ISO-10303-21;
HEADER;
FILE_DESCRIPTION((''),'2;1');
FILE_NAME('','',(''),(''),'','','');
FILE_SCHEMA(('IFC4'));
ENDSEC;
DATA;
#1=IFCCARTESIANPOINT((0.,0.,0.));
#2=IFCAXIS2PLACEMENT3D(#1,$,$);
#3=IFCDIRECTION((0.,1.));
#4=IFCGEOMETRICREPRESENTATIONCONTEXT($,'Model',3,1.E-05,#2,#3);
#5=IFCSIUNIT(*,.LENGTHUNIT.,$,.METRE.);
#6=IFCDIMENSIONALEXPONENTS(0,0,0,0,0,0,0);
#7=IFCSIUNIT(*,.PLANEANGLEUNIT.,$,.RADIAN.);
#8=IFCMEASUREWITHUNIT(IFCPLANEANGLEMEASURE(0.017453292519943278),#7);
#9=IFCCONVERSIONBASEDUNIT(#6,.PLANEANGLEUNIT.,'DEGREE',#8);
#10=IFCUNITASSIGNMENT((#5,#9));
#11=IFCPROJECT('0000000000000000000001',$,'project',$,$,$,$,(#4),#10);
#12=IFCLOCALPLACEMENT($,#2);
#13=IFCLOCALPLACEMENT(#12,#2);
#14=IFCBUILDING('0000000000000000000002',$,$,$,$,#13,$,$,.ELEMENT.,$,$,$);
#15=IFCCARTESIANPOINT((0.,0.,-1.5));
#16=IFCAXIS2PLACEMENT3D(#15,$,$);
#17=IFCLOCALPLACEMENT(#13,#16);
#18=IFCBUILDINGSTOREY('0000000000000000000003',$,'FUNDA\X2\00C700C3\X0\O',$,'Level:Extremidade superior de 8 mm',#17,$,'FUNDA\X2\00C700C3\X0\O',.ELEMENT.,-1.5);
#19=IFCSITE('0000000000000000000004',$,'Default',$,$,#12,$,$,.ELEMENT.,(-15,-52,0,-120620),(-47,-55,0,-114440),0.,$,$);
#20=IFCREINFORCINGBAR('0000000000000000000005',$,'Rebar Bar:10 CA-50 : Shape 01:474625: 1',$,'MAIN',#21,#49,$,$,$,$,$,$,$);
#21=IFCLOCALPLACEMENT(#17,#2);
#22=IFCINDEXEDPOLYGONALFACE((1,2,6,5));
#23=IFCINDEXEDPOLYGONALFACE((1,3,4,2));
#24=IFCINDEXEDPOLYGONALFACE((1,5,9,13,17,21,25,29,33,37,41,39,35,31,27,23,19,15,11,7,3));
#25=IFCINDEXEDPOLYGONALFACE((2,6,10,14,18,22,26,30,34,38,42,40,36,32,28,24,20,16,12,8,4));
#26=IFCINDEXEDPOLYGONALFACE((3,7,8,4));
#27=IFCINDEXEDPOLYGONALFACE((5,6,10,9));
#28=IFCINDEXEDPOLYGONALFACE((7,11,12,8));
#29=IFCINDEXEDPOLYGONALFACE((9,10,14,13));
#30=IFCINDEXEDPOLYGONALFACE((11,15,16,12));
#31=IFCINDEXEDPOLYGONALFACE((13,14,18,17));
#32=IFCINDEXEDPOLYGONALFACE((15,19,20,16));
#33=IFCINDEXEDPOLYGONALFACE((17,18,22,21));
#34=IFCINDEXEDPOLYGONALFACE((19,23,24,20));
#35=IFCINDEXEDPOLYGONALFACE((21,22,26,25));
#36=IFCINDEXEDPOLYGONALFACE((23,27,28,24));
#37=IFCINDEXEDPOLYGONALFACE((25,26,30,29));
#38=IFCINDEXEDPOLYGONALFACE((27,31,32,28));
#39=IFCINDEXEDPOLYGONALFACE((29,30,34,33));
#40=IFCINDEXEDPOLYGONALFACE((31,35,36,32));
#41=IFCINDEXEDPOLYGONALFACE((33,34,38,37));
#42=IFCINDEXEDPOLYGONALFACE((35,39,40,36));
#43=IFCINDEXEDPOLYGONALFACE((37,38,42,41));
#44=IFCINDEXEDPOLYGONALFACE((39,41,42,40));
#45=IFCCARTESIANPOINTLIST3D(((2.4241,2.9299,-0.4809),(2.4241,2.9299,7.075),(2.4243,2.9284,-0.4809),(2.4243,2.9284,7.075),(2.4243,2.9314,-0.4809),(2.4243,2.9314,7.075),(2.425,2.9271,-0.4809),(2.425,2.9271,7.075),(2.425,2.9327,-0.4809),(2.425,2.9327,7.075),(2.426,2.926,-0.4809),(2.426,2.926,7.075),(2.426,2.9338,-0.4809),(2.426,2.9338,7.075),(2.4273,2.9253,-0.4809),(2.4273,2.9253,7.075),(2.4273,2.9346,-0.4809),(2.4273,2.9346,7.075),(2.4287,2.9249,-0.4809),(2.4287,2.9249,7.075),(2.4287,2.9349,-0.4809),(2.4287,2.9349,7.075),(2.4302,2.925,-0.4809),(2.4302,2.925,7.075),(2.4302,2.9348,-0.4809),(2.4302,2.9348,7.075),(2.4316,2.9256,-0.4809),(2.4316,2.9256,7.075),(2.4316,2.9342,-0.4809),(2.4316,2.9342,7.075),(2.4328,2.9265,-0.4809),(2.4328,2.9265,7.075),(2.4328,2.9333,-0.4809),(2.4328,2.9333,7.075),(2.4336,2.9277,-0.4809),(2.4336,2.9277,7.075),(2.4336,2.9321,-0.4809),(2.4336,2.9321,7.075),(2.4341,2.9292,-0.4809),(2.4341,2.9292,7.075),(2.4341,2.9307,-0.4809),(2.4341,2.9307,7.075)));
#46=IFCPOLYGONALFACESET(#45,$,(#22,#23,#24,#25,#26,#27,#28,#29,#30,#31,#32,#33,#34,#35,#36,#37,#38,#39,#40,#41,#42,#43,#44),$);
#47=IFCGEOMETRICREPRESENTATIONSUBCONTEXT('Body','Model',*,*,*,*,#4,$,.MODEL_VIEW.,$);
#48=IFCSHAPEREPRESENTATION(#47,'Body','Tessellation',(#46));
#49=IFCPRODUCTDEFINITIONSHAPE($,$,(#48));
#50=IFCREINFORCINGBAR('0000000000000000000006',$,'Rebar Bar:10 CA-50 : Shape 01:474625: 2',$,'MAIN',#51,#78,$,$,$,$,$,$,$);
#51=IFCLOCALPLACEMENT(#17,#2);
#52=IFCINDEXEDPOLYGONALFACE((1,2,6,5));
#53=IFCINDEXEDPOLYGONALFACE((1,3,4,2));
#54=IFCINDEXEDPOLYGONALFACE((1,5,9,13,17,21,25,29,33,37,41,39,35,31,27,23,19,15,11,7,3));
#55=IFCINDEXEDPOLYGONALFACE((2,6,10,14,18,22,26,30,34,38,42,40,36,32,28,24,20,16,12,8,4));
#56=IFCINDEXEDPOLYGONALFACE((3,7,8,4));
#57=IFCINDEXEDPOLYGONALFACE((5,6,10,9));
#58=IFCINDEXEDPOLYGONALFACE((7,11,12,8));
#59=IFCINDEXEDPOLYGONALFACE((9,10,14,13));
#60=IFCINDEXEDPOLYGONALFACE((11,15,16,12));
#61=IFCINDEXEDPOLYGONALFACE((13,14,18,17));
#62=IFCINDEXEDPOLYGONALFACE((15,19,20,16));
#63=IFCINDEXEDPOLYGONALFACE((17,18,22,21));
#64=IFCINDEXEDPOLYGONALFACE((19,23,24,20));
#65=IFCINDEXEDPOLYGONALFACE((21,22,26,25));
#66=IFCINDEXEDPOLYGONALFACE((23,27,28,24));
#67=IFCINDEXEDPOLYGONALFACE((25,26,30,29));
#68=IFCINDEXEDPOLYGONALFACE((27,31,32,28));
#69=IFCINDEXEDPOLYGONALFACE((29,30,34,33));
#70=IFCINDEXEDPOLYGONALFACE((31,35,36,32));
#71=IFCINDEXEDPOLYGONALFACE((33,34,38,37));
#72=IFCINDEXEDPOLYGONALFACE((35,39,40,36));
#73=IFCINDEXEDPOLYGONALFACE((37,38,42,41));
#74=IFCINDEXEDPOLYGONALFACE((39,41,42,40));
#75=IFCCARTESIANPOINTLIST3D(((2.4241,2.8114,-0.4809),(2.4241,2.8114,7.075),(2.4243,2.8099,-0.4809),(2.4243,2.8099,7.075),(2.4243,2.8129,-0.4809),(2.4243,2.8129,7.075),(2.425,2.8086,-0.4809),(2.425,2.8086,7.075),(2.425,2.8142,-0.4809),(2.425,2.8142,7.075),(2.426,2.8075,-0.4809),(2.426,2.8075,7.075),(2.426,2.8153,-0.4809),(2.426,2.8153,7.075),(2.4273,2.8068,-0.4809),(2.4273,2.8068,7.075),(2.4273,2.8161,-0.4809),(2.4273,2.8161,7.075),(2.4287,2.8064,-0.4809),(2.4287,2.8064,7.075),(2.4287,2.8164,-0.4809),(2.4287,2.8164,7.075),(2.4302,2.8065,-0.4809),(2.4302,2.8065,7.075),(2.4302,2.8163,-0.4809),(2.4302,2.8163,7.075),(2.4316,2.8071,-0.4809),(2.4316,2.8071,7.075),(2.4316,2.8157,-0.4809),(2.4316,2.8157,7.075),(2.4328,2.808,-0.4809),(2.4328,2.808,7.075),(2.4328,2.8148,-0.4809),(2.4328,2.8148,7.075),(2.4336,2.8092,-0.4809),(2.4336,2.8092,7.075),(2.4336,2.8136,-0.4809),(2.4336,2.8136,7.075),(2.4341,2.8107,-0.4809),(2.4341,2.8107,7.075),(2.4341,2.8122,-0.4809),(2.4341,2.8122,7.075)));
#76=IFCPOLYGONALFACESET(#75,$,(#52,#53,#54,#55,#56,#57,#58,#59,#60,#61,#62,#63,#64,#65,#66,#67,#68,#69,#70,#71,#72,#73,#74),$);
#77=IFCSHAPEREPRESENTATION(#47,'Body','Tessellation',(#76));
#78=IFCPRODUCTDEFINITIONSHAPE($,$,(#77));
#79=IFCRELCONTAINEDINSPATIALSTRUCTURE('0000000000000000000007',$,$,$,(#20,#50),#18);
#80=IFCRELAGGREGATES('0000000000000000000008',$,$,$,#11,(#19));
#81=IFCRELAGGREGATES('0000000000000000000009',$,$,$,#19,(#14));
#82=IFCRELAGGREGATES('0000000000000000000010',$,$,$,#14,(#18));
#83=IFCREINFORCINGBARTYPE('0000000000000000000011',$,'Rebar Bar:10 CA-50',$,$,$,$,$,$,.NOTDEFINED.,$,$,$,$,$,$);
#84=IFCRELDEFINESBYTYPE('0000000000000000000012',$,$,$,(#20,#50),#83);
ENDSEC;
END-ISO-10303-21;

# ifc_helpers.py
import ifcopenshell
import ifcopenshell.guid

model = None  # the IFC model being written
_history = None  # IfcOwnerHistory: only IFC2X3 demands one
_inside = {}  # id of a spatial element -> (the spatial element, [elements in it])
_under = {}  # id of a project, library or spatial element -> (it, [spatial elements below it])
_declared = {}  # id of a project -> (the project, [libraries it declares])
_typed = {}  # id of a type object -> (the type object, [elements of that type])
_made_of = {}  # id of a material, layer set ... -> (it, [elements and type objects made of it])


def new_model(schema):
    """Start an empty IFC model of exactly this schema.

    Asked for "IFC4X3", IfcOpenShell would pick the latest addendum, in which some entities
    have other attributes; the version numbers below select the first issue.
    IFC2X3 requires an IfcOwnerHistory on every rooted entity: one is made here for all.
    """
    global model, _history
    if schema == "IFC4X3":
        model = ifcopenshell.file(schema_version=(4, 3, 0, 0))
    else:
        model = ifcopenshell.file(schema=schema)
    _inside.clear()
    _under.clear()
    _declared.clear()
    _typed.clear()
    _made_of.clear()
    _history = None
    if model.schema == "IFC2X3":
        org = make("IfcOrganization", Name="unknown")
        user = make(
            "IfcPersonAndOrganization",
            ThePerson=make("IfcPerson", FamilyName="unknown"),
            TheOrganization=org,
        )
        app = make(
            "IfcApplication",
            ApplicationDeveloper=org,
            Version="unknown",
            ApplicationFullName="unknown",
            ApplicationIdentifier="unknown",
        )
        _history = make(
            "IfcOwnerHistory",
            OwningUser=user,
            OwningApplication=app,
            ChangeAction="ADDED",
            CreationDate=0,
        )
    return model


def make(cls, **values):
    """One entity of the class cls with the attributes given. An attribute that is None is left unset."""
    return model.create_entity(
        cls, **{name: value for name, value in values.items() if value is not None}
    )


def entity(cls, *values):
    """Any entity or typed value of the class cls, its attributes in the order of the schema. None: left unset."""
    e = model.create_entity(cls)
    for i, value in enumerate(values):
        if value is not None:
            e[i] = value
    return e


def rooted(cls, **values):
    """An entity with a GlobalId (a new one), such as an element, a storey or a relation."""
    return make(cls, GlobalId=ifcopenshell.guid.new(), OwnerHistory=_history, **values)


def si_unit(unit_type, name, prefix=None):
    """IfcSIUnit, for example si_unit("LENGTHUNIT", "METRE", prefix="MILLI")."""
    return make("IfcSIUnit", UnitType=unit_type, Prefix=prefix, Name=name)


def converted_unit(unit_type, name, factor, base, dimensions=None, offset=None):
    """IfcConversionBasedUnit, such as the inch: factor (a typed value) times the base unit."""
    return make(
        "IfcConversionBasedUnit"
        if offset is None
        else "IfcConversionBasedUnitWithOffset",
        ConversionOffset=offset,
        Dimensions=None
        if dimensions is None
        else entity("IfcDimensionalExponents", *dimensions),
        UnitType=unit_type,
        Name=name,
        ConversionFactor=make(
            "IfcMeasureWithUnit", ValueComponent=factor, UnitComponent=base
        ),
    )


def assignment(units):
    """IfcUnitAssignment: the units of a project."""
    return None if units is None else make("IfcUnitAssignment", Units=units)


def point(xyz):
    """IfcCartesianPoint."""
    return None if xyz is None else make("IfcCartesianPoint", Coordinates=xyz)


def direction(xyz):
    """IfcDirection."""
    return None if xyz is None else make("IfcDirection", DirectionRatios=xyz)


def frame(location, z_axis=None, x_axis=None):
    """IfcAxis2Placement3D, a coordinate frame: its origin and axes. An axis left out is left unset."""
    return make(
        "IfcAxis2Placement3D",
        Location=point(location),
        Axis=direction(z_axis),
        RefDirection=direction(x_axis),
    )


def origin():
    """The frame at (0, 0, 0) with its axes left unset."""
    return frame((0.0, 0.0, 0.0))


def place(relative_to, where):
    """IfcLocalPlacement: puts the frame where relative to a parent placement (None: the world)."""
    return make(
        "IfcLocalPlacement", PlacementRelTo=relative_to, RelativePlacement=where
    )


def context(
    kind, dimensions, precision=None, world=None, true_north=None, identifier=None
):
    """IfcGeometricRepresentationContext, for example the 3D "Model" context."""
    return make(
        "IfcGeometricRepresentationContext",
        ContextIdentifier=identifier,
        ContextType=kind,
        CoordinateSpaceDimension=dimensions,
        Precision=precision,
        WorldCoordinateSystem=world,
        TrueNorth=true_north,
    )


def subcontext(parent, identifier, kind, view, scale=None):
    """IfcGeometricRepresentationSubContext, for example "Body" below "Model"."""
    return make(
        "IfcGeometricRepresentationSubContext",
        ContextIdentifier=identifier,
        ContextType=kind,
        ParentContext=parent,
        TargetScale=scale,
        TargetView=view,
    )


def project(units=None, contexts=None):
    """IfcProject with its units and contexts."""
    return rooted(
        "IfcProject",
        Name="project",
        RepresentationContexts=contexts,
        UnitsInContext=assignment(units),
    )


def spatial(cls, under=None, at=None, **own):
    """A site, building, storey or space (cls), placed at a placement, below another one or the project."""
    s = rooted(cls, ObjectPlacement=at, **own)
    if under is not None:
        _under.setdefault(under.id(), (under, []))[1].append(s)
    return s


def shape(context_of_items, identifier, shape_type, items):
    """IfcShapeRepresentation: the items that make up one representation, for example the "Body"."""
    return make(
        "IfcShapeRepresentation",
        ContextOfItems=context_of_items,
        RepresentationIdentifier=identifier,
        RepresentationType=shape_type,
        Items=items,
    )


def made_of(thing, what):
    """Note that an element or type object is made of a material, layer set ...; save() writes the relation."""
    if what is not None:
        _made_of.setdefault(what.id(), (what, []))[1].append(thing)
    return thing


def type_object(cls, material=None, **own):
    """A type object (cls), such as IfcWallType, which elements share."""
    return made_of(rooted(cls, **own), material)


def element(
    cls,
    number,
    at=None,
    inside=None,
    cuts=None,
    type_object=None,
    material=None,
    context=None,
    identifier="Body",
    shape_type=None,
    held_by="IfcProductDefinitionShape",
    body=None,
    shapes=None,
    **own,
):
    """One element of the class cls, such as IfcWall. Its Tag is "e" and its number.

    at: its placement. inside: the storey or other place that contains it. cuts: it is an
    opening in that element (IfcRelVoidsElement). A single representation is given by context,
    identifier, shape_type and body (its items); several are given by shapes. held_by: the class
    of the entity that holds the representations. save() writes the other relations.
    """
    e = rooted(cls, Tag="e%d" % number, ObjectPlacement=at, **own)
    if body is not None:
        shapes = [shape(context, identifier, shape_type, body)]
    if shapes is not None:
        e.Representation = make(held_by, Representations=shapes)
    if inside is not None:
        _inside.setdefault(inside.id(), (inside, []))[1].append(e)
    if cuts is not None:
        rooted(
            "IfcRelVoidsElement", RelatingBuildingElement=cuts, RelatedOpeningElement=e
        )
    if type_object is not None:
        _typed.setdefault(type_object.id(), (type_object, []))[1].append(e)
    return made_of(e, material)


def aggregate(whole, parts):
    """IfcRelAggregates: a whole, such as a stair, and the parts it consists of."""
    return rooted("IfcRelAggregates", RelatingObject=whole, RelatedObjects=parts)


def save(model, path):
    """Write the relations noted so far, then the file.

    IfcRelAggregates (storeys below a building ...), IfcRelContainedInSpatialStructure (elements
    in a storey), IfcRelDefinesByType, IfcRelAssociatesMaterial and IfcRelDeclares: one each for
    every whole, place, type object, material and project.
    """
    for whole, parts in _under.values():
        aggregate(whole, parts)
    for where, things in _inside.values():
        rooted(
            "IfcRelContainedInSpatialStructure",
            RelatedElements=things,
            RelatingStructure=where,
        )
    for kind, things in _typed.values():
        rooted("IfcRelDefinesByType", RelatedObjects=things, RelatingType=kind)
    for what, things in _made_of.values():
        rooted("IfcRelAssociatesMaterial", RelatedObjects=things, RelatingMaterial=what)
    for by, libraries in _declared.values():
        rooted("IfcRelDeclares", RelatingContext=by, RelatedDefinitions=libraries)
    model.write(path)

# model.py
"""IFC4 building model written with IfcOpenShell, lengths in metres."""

from ifc_helpers import new_model, entity, si_unit, converted_unit, direction, frame, origin, place, context, subcontext, project, spatial, type_object, element, save


model = new_model("IFC4")

# Units and contexts
model_context = context("Model", 3, precision=1e-05, world=origin(), true_north=direction((0.0, 1.0)))
body_context = subcontext(model_context, "Body", "Model", "MODEL_VIEW")
ifc_project = project(units=[si_unit("LENGTHUNIT", "METRE"), converted_unit("PLANEANGLEUNIT", "DEGREE", entity("IfcPlaneAngleMeasure", 0.017453292519943278), si_unit("PLANEANGLEUNIT", "RADIAN"), dimensions=[0, 0, 0, 0, 0, 0, 0])], contexts=[model_context])

# Site, building, storey
site_placement = place(None, origin())
site = spatial("IfcSite", under=ifc_project, at=site_placement, Name="Default", CompositionType="ELEMENT", RefLatitude=(-15, -52, 0, -120620), RefLongitude=(-47, -55, 0, -114440), RefElevation=0.0)
building_placement = place(site_placement, origin())
building = spatial("IfcBuilding", under=site, at=building_placement, CompositionType="ELEMENT")
storey_placement = place(building_placement, frame((0.0, 0.0, -1.5)))
storey = spatial("IfcBuildingStorey", under=building, at=storey_placement, Name="FUNDAÇÃO", ObjectType="Level:Extremidade superior de 8 mm", LongName="FUNDAÇÃO", CompositionType="ELEMENT", Elevation=-1.5)

# Reinforcing bars
reinforcing_bar_type_1 = type_object("IfcReinforcingBarType", Name="Rebar Bar:10 CA-50", PredefinedType="NOTDEFINED")
reinforcing_bar_1_placement = place(storey_placement, origin())
element("IfcReinforcingBar", 1, at=reinforcing_bar_1_placement, inside=storey, type_object=reinforcing_bar_type_1, Name="Rebar Bar:10 CA-50 : Shape 01:474625: 1", ObjectType="MAIN", context=body_context, shape_type="AdvancedSweptSolid", body=[
    entity("IfcSweptDiskSolid", entity("IfcIndexedPolyCurve", entity("IfcCartesianPointList3D", [[2.4291, 2.9299, 7.075], [2.4291, 2.9299, -0.4809]]), None, False), 0.005, None, 0.0, 1.0),
])
reinforcing_bar_2_placement = place(storey_placement, origin())
element("IfcReinforcingBar", 2, at=reinforcing_bar_2_placement, inside=storey, type_object=reinforcing_bar_type_1, Name="Rebar Bar:10 CA-50 : Shape 01:474625: 2", ObjectType="MAIN", context=body_context, shape_type="AdvancedSweptSolid", body=[
    entity("IfcSweptDiskSolid", entity("IfcIndexedPolyCurve", entity("IfcCartesianPointList3D", [[2.4291, 2.8114, 7.075], [2.4291, 2.8114, -0.4809]]), None, False), 0.005, None, 0.0, 1.0),
])

save(model, "model.ifc")
